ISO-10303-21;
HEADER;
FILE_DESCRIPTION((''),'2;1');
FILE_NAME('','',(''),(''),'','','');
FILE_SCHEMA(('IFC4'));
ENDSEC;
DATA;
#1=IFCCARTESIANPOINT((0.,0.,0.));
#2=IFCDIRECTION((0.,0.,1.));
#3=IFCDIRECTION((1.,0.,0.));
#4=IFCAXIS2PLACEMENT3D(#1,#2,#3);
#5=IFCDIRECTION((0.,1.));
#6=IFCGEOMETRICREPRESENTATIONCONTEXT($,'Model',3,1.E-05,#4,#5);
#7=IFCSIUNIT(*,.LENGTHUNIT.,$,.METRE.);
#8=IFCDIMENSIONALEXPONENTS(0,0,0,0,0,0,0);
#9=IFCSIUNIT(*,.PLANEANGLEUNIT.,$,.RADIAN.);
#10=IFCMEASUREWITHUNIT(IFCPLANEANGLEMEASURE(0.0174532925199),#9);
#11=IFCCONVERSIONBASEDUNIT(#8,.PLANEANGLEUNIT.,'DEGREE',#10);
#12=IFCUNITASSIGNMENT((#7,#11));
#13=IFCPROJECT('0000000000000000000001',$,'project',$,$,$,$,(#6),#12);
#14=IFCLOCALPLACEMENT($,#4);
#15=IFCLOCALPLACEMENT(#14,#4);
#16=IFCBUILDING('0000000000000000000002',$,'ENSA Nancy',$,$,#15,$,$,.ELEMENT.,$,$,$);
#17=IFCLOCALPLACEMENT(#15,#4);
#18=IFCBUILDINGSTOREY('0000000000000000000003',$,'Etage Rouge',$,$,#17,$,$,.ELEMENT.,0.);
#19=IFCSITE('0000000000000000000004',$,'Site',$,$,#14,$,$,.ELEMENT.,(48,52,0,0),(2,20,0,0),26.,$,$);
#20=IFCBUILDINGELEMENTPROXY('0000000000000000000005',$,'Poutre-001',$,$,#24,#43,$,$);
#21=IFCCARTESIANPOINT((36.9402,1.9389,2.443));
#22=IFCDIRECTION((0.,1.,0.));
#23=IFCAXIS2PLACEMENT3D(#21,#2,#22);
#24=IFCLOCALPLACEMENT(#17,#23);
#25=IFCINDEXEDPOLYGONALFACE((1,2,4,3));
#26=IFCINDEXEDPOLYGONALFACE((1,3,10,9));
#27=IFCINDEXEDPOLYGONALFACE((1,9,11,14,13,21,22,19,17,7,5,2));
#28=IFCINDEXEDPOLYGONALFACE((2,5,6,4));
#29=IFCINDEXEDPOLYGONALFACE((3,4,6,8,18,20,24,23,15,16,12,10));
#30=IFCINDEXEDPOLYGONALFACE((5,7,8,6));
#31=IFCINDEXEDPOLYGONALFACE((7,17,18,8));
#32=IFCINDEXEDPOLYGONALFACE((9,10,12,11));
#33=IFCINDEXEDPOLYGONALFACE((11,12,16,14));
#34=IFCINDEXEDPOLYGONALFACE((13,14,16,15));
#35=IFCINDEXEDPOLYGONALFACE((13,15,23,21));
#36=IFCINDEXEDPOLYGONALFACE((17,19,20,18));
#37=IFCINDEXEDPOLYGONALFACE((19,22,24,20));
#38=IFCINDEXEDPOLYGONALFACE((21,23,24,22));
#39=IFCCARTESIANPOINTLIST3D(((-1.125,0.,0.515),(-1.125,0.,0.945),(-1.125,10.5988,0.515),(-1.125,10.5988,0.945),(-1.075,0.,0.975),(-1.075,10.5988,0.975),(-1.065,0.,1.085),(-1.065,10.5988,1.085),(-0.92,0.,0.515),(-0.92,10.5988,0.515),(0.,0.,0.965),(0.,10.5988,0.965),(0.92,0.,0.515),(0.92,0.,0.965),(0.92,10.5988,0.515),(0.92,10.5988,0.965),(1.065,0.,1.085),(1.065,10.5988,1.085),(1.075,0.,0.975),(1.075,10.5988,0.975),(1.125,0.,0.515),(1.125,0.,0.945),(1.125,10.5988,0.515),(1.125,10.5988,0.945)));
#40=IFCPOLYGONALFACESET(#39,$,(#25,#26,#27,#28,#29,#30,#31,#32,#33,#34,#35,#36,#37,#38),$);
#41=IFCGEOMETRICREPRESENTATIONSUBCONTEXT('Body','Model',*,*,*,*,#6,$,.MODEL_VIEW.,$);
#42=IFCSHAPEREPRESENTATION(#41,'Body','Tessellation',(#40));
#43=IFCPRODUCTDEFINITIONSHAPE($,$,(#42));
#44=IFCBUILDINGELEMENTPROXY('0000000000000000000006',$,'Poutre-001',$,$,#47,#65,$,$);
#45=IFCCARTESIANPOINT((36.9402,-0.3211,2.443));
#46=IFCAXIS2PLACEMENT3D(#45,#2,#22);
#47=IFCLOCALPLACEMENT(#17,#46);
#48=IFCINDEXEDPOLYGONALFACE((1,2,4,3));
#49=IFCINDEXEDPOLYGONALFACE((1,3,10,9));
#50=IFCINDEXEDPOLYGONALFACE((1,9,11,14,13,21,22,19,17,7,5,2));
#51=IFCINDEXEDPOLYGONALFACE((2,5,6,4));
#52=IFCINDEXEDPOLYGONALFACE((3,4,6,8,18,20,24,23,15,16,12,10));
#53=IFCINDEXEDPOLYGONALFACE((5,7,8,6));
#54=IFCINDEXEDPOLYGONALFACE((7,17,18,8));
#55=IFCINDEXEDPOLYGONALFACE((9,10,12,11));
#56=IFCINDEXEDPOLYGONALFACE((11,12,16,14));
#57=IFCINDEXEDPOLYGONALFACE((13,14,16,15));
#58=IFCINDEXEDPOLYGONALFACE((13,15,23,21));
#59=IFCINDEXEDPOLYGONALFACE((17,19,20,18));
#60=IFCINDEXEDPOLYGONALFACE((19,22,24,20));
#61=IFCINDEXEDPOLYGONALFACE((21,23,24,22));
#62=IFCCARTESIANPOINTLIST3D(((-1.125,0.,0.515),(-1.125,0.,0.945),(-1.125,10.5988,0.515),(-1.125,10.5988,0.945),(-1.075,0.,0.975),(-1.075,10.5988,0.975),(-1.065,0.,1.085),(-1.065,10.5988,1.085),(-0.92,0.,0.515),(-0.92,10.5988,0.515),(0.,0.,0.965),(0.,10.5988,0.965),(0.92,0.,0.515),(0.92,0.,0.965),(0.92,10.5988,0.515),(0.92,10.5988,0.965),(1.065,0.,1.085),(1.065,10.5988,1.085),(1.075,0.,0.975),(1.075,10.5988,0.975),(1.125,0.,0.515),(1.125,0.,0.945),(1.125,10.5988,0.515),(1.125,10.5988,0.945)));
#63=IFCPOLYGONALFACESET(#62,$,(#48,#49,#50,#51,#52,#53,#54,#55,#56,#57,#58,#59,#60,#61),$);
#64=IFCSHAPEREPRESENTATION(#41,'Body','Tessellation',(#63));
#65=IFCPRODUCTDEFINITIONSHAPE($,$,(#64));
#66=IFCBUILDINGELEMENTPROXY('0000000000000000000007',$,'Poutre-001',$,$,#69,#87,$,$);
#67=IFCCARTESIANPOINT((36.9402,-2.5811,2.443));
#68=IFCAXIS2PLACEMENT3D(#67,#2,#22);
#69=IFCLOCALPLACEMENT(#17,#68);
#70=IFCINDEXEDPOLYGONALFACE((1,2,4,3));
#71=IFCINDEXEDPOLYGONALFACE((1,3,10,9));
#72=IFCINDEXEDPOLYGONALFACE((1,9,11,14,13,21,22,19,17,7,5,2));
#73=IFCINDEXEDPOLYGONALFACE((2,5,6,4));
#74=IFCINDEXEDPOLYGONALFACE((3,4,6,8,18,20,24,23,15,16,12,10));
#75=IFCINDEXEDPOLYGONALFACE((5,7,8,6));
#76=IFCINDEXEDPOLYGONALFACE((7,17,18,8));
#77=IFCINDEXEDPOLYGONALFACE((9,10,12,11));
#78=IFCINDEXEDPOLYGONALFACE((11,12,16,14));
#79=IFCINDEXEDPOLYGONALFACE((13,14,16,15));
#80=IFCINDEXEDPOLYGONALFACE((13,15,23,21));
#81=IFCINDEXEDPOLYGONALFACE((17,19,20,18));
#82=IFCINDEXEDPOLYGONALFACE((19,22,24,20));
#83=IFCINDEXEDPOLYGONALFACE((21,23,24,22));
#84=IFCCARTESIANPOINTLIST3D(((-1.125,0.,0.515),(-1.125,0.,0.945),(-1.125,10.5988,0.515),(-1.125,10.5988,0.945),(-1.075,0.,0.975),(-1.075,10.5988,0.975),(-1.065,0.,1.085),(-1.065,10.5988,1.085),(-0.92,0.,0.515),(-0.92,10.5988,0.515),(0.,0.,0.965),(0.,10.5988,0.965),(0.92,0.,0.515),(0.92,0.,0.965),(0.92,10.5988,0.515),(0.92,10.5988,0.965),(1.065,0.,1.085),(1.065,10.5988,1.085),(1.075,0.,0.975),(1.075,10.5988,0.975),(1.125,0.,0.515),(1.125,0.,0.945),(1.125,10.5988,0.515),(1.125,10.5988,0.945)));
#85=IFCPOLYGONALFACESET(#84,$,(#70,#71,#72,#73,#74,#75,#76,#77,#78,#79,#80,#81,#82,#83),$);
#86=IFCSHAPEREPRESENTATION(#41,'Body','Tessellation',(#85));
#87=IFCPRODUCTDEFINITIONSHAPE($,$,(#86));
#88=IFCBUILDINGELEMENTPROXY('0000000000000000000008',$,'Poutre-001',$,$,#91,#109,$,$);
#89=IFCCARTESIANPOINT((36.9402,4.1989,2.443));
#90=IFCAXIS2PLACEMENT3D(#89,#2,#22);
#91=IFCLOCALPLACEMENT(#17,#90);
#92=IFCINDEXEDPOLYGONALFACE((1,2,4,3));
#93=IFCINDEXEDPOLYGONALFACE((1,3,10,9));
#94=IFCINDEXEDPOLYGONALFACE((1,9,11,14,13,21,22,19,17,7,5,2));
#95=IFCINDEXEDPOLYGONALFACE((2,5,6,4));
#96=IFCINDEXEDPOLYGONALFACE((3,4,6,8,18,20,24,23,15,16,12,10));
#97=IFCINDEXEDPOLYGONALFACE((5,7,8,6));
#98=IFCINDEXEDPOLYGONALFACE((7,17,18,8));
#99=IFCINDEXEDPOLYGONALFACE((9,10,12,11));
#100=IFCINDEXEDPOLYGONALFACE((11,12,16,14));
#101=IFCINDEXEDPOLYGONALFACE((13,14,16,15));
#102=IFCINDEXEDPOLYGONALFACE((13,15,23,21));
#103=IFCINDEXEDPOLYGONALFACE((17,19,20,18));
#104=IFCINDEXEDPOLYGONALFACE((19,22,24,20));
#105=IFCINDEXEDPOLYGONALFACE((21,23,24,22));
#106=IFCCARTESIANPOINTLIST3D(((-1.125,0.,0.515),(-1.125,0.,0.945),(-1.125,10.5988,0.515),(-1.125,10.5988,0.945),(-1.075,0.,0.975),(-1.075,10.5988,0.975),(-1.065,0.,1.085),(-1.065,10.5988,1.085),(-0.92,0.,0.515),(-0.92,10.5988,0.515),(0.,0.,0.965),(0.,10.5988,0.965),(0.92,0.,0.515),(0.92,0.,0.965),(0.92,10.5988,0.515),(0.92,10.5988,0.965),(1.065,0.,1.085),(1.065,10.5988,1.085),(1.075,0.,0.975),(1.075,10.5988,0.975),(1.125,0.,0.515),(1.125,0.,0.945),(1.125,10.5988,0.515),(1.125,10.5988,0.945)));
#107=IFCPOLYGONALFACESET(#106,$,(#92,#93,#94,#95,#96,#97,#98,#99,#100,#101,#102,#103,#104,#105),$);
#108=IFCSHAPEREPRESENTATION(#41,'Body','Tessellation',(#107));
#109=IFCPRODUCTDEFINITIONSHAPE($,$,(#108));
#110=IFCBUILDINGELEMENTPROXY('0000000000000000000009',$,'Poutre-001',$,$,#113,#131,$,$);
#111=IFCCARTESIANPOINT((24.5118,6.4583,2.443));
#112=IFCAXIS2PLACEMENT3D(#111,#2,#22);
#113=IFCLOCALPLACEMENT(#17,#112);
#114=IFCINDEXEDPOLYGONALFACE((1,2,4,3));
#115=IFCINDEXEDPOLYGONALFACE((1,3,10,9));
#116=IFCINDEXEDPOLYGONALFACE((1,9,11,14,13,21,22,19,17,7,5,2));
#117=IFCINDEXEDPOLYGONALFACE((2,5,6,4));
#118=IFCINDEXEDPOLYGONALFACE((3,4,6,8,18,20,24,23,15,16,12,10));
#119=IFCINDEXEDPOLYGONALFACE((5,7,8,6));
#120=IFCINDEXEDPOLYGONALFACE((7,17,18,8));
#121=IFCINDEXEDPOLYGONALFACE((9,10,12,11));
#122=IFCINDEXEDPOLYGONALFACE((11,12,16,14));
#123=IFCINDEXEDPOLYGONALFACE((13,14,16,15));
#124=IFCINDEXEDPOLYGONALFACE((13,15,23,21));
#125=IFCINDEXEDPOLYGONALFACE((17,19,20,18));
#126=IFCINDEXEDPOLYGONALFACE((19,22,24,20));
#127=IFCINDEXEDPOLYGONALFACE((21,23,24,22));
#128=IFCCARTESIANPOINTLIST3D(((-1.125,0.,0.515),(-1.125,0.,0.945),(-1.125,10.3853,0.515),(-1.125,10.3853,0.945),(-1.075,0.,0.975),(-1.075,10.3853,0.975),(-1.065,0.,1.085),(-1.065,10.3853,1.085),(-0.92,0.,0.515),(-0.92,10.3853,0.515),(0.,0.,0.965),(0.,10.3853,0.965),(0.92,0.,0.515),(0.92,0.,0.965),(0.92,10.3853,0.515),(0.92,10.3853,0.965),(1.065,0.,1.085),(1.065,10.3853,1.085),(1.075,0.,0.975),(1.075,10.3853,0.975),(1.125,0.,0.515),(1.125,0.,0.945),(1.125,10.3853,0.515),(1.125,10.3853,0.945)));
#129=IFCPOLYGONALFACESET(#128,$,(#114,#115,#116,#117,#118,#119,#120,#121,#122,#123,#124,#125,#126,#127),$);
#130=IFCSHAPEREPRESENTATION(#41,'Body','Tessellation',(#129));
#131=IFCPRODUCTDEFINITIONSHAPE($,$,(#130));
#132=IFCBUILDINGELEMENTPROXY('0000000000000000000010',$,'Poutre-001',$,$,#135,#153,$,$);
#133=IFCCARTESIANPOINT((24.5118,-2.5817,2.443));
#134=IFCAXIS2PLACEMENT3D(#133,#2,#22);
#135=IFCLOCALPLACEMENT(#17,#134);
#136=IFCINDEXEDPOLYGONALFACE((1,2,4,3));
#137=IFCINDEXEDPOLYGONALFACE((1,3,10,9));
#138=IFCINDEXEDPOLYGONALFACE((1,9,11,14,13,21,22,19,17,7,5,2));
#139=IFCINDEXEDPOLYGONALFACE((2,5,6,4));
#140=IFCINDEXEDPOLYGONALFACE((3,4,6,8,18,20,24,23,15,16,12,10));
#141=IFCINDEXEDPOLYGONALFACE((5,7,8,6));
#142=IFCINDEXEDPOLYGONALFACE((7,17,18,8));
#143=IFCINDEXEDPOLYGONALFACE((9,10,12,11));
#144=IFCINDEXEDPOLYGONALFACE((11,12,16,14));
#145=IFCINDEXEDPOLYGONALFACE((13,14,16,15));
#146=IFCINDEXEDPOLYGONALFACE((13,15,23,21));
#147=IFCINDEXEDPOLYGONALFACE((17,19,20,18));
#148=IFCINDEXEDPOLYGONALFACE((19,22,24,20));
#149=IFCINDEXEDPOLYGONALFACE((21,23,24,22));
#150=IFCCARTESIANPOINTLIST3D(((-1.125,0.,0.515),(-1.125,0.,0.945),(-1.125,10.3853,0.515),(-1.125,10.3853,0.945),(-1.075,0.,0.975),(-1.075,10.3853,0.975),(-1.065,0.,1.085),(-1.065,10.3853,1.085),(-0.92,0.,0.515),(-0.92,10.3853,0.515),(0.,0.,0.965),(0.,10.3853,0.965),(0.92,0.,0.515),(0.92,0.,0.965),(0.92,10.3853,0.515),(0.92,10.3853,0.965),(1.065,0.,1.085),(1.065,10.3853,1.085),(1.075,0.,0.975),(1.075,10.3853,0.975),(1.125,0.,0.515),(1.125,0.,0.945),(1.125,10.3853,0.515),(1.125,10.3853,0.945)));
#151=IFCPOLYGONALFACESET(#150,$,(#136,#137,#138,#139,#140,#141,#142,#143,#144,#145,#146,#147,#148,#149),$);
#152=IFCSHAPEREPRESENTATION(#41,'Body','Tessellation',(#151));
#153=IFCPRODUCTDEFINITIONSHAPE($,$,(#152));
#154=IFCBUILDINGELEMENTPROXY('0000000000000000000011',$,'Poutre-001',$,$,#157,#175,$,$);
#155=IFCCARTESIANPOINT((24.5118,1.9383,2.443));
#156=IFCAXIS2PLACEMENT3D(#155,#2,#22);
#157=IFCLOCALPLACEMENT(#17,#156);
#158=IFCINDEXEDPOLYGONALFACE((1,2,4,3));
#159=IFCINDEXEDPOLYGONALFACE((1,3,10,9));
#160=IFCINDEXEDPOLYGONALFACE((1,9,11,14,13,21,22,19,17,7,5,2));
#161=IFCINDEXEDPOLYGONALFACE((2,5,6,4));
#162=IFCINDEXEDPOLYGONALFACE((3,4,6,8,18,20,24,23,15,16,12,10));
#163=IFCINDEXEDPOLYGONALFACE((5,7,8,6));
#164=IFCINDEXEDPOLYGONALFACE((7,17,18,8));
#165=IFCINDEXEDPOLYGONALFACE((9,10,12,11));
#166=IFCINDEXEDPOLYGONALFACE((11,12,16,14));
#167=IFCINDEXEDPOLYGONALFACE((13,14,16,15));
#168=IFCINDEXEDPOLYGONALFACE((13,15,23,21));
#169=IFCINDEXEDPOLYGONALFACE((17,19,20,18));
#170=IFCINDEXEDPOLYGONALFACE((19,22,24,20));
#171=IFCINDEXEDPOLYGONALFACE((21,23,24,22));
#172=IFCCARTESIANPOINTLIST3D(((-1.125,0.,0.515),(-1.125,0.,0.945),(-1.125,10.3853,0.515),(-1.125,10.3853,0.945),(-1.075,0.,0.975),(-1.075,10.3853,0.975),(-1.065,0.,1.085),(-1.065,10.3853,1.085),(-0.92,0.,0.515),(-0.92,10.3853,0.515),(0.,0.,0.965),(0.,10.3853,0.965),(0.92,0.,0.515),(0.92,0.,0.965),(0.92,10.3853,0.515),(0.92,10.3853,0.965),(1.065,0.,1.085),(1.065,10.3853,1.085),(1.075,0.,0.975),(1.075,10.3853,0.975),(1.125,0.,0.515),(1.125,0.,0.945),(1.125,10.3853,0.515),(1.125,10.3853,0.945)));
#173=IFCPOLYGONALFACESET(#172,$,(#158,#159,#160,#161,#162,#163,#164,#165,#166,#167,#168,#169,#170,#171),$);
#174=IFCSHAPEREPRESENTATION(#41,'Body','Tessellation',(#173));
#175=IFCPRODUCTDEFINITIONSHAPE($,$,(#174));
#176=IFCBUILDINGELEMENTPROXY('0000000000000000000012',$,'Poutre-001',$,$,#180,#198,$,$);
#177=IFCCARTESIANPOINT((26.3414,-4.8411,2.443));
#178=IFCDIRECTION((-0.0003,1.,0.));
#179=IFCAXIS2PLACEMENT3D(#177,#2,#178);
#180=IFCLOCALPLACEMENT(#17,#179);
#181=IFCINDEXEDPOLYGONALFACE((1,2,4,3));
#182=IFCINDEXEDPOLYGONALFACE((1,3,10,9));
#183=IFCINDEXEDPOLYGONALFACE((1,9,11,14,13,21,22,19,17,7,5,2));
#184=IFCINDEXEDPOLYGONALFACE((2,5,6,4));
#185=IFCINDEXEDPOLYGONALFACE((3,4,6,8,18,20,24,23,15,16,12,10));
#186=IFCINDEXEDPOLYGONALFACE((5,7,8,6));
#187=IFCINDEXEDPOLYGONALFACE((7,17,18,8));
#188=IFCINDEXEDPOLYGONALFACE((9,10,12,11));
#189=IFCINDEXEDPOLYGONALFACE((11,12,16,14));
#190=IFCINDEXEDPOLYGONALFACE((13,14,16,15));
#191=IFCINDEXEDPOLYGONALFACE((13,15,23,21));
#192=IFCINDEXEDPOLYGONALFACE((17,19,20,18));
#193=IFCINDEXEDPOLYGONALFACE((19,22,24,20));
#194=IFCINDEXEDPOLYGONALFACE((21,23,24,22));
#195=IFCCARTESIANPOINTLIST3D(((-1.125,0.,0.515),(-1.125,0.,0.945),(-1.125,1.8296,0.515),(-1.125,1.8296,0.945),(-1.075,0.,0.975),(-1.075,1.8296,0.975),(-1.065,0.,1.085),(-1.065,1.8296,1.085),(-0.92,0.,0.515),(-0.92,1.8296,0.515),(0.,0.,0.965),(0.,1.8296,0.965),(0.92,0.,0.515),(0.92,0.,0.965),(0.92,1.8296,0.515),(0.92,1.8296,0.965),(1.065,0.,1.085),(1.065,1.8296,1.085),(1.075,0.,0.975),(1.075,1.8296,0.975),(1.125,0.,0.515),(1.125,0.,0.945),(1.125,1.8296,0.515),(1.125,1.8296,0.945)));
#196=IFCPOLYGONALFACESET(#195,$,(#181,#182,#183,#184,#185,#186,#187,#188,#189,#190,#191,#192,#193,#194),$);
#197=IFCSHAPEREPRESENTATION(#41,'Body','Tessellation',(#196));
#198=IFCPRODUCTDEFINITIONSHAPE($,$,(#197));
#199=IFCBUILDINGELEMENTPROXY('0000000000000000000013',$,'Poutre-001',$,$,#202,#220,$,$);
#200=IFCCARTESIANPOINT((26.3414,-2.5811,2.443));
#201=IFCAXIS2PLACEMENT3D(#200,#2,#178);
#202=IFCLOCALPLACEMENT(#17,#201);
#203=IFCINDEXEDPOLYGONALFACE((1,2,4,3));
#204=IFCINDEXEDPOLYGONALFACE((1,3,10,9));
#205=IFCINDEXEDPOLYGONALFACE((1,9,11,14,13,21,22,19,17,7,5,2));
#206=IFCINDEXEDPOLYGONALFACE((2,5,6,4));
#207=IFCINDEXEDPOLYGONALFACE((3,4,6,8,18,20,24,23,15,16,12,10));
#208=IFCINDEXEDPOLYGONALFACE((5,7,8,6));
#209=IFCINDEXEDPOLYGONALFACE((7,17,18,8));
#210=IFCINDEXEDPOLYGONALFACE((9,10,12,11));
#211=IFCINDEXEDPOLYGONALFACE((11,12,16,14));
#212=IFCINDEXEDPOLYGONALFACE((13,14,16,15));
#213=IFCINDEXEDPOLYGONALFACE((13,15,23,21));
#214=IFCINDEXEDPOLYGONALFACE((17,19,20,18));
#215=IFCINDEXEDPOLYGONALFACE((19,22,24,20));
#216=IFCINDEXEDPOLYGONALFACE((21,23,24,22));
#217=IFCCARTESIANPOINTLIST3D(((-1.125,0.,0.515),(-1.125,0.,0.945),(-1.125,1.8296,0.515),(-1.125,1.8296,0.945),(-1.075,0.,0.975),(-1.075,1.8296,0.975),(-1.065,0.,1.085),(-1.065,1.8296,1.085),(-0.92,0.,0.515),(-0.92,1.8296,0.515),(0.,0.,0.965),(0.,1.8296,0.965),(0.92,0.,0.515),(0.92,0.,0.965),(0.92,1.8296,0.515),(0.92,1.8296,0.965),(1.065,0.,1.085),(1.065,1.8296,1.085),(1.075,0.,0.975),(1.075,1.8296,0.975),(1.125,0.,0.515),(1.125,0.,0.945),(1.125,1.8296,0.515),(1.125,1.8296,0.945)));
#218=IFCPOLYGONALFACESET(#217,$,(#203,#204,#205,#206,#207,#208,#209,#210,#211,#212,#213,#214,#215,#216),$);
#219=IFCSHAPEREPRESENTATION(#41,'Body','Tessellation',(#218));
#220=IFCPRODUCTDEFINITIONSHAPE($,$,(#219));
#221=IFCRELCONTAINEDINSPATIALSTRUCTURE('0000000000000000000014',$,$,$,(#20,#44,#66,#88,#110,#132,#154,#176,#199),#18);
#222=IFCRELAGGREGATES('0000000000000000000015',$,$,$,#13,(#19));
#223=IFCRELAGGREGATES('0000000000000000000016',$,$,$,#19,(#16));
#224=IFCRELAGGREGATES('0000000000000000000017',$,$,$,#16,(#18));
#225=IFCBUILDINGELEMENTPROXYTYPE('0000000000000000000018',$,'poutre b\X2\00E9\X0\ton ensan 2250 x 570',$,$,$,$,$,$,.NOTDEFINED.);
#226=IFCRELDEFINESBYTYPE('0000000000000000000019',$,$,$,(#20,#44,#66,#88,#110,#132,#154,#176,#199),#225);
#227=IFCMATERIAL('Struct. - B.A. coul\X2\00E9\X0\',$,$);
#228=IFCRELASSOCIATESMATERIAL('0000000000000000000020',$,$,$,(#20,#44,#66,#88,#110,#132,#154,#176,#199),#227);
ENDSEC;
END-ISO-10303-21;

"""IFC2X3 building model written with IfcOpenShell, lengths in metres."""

from ifc_helpers import new_model, entity, si_unit, converted_unit, direction, frame, origin_with_axes, place, context, subcontext, project, spatial, polyline, outline, extrude, material, type_object, element, save


model = new_model("IFC2X3")

# Units and contexts
model_context = context("Model", 3, precision=1e-05, world=origin_with_axes(), true_north=direction((0.0, 1.0)))
body_context = subcontext(model_context, "Body", "Model", "MODEL_VIEW")
ifc_project = project(units=[si_unit("LENGTHUNIT", "METRE"), converted_unit("PLANEANGLEUNIT", "DEGREE", entity("IfcPlaneAngleMeasure", 0.0174532925199), si_unit("PLANEANGLEUNIT", "RADIAN"), dimensions=[0, 0, 0, 0, 0, 0, 0])], contexts=[model_context])

# Site, building, storey
site_placement = place(None, origin_with_axes())
site = spatial("IfcSite", under=ifc_project, at=site_placement, Name="Site", CompositionType="ELEMENT", RefLatitude=(48, 52, 0, 0), RefLongitude=(2, 20, 0, 0), RefElevation=26.0)
building_placement = place(site_placement, origin_with_axes())
building = spatial("IfcBuilding", under=site, at=building_placement, Name="ENSA Nancy", CompositionType="ELEMENT")
storey_placement = place(building_placement, origin_with_axes())
storey = spatial("IfcBuildingStorey", under=building, at=storey_placement, Name="Etage Rouge", CompositionType="ELEMENT", Elevation=0.0)

# Building element proxies
ifc_material_1 = material(Name="Struct. - B.A. coulé")
building_element_proxy_type_1 = type_object("IfcBuildingElementProxyType", Name="poutre béton ensan 2250 x 570", PredefinedType="NOTDEFINED")
for number, where, z_axis, x_axis, name in (
    (1, (36.9402, 1.9389, 2.443), (0.0, 0.0, 1.0), (0.0, 1.0, 0.0), "Poutre-001"),
    (2, (36.9402, -0.3211, 2.443), (0.0, 0.0, 1.0), (0.0, 1.0, 0.0), "Poutre-001"),
    (3, (36.9402, -2.5811, 2.443), (0.0, 0.0, 1.0), (0.0, 1.0, 0.0), "Poutre-001"),
):
    element("IfcBuildingElementProxy", number, at=place(storey_placement, frame(where, z_axis=z_axis, x_axis=x_axis)), inside=storey, type_object=building_element_proxy_type_1, material=ifc_material_1, Name=name, context=body_context, shape_type="SweptSolid", body=[
        extrude(outline(polyline([(-1.065, 1.085), (-1.075, 0.975), (-1.125, 0.945), (-1.125, 0.515), (-0.92, 0.515), (0.0, 0.965), (0.92, 0.965), (0.92, 0.515), (1.125, 0.515), (1.125, 0.945), (1.075, 0.975), (1.065, 1.085), (-1.065, 1.085)])), frame((0.0, 10.5988, 0.0), z_axis=(0.0, -1.0, 0.0), x_axis=(1.0, 0.0, 0.0)), (0.0, 0.0, 1.0), 10.5988),
    ])
proxy_1_placement = place(storey_placement, frame((36.9402, 4.1989, 2.443), z_axis=(0.0, 0.0, 1.0), x_axis=(0.0, 1.0, 0.0)))
element("IfcBuildingElementProxy", 4, at=proxy_1_placement, inside=storey, type_object=building_element_proxy_type_1, material=ifc_material_1, Name="Poutre-001", context=body_context, shape_type="SweptSolid", body=[
    extrude(outline(polyline([(-1.065, 1.085), (-1.075, 0.975), (-1.125, 0.945), (-1.125, 0.515), (-0.92, 0.515), (0.0, 0.965), (0.92, 0.965), (0.92, 0.515), (1.125, 0.515), (1.125, 0.945), (1.075, 0.975), (1.065, 1.085), (-1.065, 1.085)])), frame((0.0, 10.5988, 0.0), z_axis=(0.0, -1.0, 0.0), x_axis=(1.0, 0.0, 0.0)), (0.0, 0.0, 1.0), 10.5988),
])
for number, where, z_axis, x_axis, name in (
    (5, (24.5118, 6.4583, 2.443), (0.0, 0.0, 1.0), (0.0, 1.0, 0.0), "Poutre-001"),
    (6, (24.5118, -2.5817, 2.443), (0.0, 0.0, 1.0), (0.0, 1.0, 0.0), "Poutre-001"),
    (7, (24.5118, 1.9383, 2.443), (0.0, 0.0, 1.0), (0.0, 1.0, 0.0), "Poutre-001"),
):
    element("IfcBuildingElementProxy", number, at=place(storey_placement, frame(where, z_axis=z_axis, x_axis=x_axis)), inside=storey, type_object=building_element_proxy_type_1, material=ifc_material_1, Name=name, context=body_context, shape_type="SweptSolid", body=[
        extrude(outline(polyline([(-1.065, 1.085), (-1.075, 0.975), (-1.125, 0.945), (-1.125, 0.515), (-0.92, 0.515), (0.0, 0.965), (0.92, 0.965), (0.92, 0.515), (1.125, 0.515), (1.125, 0.945), (1.075, 0.975), (1.065, 1.085), (-1.065, 1.085)])), frame((0.0, 10.3853, 0.0), z_axis=(0.0, -1.0, 0.0), x_axis=(1.0, 0.0, 0.0)), (0.0, 0.0, 1.0), 10.3853),
    ])
for number, where, z_axis, x_axis, name in (
    (8, (26.3414, -4.8411, 2.443), (0.0, 0.0, 1.0), (-0.0003, 1.0, 0.0), "Poutre-001"),
    (9, (26.3414, -2.5811, 2.443), (0.0, 0.0, 1.0), (-0.0003, 1.0, 0.0), "Poutre-001"),
):
    element("IfcBuildingElementProxy", number, at=place(storey_placement, frame(where, z_axis=z_axis, x_axis=x_axis)), inside=storey, type_object=building_element_proxy_type_1, material=ifc_material_1, Name=name, context=body_context, shape_type="SweptSolid", body=[
        extrude(outline(polyline([(-1.065, 1.085), (-1.075, 0.975), (-1.125, 0.945), (-1.125, 0.515), (-0.92, 0.515), (0.0, 0.965), (0.92, 0.965), (0.92, 0.515), (1.125, 0.515), (1.125, 0.945), (1.075, 0.975), (1.065, 1.085), (-1.065, 1.085)])), frame((0.0, 1.8296, 0.0), z_axis=(0.0, -1.0, 0.0), x_axis=(1.0, 0.0, 0.0)), (0.0, 0.0, 1.0), 1.8296),
    ])

save(model, "model.ifc")
